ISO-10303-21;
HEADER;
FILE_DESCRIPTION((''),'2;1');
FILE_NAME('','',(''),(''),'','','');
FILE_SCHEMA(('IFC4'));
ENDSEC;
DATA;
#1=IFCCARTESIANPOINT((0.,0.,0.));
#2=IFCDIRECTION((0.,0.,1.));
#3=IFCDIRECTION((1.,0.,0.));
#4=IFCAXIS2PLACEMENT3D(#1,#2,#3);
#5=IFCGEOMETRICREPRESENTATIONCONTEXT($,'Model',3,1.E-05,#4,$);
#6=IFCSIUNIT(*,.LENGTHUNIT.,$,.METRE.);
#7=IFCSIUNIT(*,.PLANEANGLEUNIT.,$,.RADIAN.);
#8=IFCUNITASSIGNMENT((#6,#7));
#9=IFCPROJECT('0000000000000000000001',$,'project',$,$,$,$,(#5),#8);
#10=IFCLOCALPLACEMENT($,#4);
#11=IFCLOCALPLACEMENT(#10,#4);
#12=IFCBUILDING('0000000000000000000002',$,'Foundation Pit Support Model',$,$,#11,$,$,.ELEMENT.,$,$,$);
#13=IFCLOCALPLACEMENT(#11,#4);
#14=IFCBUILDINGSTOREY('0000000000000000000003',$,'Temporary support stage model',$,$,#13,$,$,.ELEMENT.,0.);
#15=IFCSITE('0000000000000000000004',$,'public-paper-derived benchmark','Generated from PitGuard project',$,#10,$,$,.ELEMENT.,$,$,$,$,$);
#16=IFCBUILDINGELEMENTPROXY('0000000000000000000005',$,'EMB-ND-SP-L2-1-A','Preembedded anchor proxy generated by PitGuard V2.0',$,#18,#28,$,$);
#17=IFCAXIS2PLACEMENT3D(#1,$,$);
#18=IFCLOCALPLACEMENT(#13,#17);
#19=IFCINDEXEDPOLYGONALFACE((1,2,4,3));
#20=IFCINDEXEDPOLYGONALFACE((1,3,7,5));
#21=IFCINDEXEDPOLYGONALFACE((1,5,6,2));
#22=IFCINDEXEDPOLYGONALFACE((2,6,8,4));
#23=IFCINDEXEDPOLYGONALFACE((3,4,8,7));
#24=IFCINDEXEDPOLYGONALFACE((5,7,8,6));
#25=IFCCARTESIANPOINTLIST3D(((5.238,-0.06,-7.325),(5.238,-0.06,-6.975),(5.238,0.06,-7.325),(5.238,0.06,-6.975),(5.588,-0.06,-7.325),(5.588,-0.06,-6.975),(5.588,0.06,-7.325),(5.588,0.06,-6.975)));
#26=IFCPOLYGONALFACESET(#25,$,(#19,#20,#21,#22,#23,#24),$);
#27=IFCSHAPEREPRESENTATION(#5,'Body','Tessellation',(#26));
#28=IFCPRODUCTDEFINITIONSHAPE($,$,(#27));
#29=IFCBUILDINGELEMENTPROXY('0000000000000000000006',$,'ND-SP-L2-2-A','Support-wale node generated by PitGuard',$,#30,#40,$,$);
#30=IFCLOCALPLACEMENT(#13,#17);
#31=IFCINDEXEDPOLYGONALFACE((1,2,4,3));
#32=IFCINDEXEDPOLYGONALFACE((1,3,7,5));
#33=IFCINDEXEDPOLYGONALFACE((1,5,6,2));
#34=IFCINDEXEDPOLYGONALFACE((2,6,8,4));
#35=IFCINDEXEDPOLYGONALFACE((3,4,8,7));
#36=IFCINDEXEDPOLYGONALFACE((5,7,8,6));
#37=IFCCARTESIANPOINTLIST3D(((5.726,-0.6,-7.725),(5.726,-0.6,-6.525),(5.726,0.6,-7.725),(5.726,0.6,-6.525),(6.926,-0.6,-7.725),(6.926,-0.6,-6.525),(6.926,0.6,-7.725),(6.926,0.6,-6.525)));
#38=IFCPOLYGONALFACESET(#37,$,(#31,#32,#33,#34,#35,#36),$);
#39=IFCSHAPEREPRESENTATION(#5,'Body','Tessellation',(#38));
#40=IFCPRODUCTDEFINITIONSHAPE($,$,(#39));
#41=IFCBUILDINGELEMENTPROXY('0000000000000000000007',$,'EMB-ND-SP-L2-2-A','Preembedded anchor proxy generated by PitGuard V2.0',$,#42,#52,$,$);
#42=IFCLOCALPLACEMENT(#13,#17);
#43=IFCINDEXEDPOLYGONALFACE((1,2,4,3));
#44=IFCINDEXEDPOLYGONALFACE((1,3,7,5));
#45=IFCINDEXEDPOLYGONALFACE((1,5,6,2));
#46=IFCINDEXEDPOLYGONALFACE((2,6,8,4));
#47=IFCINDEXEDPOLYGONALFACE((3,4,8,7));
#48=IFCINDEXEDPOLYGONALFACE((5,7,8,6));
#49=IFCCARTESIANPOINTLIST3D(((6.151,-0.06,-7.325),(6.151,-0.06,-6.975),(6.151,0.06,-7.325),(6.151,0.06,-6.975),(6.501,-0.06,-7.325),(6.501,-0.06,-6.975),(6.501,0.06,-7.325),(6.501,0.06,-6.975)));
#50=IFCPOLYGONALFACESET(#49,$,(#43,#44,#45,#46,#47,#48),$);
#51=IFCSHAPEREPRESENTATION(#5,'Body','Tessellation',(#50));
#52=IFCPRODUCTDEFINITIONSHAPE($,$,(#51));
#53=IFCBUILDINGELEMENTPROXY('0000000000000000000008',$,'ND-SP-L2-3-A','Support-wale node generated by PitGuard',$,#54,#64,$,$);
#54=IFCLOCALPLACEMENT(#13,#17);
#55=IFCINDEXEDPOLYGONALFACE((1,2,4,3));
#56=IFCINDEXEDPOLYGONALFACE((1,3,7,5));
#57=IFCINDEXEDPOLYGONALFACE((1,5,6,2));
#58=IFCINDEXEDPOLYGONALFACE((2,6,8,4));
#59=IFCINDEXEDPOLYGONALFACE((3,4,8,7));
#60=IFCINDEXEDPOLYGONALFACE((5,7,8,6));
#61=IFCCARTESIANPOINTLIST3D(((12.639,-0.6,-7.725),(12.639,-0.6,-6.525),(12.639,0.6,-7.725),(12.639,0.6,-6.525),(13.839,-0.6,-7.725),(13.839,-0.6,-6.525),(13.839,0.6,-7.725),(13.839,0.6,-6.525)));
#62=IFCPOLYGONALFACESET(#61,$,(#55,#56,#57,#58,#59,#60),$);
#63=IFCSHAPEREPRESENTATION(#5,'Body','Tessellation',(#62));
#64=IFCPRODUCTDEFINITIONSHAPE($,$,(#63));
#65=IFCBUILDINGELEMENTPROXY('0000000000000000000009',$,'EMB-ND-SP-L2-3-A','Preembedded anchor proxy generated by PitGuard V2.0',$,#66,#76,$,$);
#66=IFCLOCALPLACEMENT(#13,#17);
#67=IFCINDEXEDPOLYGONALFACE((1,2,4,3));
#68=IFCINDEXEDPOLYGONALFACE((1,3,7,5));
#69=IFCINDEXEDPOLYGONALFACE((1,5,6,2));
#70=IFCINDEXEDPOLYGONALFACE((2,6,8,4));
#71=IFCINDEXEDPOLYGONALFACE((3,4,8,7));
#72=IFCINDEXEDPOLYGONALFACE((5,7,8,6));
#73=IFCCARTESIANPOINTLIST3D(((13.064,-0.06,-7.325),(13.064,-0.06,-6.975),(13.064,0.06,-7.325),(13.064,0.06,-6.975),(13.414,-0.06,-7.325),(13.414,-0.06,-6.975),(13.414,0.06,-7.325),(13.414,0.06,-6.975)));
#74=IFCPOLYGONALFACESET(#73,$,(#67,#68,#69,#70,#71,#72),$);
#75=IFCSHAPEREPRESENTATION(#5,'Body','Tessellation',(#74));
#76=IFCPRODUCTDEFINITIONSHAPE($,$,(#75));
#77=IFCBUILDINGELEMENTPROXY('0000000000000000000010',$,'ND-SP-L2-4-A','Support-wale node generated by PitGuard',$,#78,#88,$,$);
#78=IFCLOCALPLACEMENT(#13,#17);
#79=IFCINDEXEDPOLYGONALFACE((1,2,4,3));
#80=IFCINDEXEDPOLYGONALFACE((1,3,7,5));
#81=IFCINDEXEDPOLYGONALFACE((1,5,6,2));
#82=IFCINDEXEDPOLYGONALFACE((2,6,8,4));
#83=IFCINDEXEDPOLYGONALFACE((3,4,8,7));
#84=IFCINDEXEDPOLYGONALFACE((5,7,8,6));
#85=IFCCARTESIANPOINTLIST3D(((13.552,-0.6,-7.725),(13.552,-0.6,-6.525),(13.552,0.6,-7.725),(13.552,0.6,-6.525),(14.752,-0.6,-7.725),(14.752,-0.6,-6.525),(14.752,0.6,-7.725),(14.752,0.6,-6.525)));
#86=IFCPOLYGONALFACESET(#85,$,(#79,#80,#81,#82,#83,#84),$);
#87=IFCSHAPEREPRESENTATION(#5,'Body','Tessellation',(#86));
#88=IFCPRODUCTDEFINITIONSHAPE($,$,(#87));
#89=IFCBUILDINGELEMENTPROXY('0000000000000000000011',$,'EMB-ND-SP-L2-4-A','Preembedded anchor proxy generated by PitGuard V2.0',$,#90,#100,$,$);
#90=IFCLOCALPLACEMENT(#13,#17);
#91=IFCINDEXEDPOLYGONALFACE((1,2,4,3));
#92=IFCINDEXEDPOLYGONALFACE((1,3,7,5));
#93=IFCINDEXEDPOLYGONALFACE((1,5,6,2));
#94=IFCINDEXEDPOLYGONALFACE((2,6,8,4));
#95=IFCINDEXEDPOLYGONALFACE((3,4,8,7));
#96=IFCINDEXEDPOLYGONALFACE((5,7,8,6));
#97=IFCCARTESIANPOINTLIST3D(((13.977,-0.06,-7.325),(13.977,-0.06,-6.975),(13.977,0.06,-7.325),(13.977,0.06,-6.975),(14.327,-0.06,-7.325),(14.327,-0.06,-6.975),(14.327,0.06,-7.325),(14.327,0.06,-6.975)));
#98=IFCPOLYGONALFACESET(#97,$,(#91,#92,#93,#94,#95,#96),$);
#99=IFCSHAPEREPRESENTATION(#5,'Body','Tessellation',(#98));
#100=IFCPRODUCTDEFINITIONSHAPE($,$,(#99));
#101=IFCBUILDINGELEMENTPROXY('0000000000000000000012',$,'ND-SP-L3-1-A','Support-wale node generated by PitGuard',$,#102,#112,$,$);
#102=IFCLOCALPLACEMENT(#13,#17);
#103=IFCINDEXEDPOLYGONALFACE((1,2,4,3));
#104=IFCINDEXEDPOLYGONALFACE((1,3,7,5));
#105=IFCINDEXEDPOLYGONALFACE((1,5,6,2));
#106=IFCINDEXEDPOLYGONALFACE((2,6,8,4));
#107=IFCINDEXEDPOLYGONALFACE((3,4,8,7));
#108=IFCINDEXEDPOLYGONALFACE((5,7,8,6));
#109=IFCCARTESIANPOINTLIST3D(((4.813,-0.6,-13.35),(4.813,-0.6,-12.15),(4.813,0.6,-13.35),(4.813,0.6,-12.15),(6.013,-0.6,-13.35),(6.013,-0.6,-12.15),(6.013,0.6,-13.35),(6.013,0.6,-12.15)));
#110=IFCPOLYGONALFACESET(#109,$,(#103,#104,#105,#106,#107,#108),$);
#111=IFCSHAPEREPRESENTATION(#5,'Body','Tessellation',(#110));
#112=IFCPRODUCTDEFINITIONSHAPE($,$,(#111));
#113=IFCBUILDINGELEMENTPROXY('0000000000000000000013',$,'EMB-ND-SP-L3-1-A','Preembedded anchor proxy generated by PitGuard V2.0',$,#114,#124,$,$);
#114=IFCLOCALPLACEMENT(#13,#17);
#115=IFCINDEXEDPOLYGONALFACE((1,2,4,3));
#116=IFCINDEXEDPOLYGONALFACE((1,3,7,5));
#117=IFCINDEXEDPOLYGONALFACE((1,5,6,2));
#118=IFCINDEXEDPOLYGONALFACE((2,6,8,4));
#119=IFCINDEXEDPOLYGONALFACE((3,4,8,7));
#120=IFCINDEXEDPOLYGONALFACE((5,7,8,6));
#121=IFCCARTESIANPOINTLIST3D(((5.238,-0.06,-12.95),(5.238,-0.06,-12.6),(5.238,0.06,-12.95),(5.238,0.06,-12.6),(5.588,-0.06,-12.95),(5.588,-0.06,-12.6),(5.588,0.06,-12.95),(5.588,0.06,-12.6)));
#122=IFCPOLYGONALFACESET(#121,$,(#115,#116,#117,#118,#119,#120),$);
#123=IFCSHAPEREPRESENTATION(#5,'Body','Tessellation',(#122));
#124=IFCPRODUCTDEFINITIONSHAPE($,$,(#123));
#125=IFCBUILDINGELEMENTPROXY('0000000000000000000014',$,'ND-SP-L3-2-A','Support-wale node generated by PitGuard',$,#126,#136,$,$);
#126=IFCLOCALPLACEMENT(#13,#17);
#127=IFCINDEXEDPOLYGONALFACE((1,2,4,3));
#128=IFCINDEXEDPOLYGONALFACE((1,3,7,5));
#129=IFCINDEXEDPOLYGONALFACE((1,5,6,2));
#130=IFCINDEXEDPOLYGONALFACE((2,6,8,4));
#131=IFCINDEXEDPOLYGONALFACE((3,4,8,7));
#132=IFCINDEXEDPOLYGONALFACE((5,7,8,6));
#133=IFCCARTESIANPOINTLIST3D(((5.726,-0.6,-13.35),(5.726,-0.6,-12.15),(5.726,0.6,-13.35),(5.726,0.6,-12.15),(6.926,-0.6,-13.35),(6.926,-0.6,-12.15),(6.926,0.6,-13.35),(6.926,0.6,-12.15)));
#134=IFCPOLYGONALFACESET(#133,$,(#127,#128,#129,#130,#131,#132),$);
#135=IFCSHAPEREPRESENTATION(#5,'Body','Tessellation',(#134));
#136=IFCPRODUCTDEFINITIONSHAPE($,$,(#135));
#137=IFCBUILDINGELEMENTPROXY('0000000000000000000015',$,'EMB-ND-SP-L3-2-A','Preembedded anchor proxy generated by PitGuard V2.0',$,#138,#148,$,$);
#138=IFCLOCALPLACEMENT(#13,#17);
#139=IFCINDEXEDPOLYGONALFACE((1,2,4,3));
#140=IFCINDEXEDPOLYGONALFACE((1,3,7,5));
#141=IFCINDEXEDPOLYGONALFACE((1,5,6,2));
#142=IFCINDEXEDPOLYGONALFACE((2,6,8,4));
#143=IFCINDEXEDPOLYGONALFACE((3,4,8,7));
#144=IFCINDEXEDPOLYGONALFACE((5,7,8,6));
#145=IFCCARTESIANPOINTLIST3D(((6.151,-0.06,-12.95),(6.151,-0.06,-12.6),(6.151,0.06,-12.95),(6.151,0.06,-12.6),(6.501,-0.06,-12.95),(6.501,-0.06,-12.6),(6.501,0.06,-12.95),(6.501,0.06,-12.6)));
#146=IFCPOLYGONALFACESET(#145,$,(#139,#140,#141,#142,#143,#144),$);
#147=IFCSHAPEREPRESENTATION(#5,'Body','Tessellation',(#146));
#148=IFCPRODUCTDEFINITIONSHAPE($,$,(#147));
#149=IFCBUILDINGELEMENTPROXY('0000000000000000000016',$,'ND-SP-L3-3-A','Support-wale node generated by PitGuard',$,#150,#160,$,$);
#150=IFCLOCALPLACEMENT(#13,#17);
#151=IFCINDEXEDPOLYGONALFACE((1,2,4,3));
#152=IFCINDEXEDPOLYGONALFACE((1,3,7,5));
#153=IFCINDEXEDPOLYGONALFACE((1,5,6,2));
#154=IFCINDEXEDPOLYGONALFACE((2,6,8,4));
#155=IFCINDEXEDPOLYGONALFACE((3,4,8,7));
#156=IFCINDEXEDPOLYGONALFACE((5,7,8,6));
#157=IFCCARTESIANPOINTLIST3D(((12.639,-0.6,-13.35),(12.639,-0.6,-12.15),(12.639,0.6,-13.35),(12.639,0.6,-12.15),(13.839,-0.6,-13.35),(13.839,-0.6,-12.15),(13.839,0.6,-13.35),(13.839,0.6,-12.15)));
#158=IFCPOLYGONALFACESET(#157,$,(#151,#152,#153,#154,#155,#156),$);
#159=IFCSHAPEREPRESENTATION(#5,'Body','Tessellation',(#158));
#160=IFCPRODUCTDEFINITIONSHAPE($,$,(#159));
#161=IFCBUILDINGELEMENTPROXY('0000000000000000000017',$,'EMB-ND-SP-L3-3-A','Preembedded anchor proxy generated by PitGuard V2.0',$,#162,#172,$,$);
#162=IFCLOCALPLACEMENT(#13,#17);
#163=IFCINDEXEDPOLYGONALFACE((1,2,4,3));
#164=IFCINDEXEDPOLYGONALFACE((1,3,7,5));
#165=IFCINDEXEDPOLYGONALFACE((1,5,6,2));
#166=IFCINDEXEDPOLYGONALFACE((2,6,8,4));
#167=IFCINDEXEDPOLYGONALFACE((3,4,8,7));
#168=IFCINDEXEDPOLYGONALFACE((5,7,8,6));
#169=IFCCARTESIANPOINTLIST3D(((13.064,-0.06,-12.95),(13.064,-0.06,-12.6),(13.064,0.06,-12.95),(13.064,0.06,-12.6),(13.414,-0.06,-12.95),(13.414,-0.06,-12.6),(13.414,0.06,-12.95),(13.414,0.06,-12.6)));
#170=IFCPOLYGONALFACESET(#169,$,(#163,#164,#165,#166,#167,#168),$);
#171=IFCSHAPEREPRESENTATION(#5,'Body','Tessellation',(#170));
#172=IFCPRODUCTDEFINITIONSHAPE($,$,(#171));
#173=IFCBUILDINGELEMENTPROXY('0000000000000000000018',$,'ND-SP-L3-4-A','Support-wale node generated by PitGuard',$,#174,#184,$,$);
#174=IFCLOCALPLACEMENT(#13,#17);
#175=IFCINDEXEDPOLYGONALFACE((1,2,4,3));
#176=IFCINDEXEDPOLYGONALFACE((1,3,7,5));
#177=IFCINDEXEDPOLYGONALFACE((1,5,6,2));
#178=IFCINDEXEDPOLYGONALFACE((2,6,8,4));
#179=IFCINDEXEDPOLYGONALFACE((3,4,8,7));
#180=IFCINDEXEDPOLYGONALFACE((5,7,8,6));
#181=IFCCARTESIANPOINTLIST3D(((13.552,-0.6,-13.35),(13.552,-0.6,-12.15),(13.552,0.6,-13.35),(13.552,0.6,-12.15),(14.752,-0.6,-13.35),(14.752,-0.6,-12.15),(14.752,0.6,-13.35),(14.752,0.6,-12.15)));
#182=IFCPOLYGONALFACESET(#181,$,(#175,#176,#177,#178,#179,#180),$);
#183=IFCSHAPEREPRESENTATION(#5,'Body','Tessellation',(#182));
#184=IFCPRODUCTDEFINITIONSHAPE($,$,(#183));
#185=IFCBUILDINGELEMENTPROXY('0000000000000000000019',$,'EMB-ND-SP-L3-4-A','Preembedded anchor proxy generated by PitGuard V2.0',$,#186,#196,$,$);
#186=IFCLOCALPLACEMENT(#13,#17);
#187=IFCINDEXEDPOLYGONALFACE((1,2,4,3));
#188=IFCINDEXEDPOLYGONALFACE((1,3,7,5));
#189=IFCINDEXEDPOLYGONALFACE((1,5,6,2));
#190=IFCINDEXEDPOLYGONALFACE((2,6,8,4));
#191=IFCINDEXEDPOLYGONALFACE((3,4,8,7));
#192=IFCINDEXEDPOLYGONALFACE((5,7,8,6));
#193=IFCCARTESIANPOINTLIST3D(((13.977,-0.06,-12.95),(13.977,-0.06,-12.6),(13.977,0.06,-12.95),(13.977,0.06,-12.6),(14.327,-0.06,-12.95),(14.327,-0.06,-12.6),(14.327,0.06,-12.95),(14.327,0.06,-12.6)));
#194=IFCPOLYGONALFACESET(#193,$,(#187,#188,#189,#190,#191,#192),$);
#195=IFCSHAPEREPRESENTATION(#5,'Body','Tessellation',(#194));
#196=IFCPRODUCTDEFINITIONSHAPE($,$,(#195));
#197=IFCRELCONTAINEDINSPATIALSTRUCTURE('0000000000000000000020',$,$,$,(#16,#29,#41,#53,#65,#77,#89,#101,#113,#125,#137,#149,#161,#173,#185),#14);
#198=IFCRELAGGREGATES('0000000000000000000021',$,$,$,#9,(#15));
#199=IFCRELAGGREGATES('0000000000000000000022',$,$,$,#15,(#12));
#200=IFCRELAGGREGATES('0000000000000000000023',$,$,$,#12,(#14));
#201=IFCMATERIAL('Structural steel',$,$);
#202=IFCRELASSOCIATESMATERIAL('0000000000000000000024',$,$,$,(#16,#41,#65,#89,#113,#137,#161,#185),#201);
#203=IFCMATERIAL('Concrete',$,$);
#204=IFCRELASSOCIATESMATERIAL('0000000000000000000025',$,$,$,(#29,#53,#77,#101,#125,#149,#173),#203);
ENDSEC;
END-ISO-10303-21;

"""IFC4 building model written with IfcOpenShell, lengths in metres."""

from ifc_helpers import new_model, si_unit, frame, origin_with_axes, origin_2d, place, context, project, spatial, rectangle, extrude, material, element, save


model = new_model("IFC4")

# Units and contexts
model_context = context("Model", 3, precision=1e-05, world=origin_with_axes())
ifc_project = project(units=[si_unit("LENGTHUNIT", "METRE"), si_unit("PLANEANGLEUNIT", "RADIAN")], contexts=[model_context])

# Site, building, storey
site_placement = place(None, origin_with_axes())
site = spatial("IfcSite", under=ifc_project, at=site_placement, Name="public-paper-derived benchmark", Description="Generated from PitGuard project", CompositionType="ELEMENT")
building_placement = place(site_placement, origin_with_axes())
building = spatial("IfcBuilding", under=site, at=building_placement, Name="Foundation Pit Support Model", CompositionType="ELEMENT")
storey_placement = place(building_placement, origin_with_axes())
storey = spatial("IfcBuildingStorey", under=building, at=storey_placement, Name="Temporary support stage model", CompositionType="ELEMENT", Elevation=0.0)

# Shared definitions
ifc_material_1 = material(Name="Structural steel")

# Building element proxies
ifc_material_2 = material(Name="Concrete")
proxy_1_placement = place(storey_placement, frame((5.413, 0.0, -7.325), z_axis=(0.0, 0.0, 1.0), x_axis=(1.0, 0.0, 0.0)))
element("IfcBuildingElementProxy", 1, at=proxy_1_placement, inside=storey, material=ifc_material_1, Name="EMB-ND-SP-L2-1-A", Description="Preembedded anchor proxy generated by PitGuard V2.0", context=model_context, shape_type="SweptSolid", body=[
    extrude(rectangle(XDim=0.35, YDim=0.12, at=origin_2d()), origin_with_axes(), (0.0, 0.0, 1.0), 0.35),
])
proxy_2_placement = place(storey_placement, frame((6.326, 0.0, -7.725), z_axis=(0.0, 0.0, 1.0), x_axis=(1.0, 0.0, 0.0)))
element("IfcBuildingElementProxy", 2, at=proxy_2_placement, inside=storey, material=ifc_material_2, Name="ND-SP-L2-2-A", Description="Support-wale node generated by PitGuard", context=model_context, shape_type="SweptSolid", body=[
    extrude(rectangle(XDim=1.2, YDim=1.2, at=origin_2d()), origin_with_axes(), (0.0, 0.0, 1.0), 1.2),
])
proxy_3_placement = place(storey_placement, frame((6.326, 0.0, -7.325), z_axis=(0.0, 0.0, 1.0), x_axis=(1.0, 0.0, 0.0)))
element("IfcBuildingElementProxy", 3, at=proxy_3_placement, inside=storey, material=ifc_material_1, Name="EMB-ND-SP-L2-2-A", Description="Preembedded anchor proxy generated by PitGuard V2.0", context=model_context, shape_type="SweptSolid", body=[
    extrude(rectangle(XDim=0.35, YDim=0.12, at=origin_2d()), origin_with_axes(), (0.0, 0.0, 1.0), 0.35),
])
proxy_4_placement = place(storey_placement, frame((13.239, 0.0, -7.725), z_axis=(0.0, 0.0, 1.0), x_axis=(1.0, 0.0, 0.0)))
element("IfcBuildingElementProxy", 4, at=proxy_4_placement, inside=storey, material=ifc_material_2, Name="ND-SP-L2-3-A", Description="Support-wale node generated by PitGuard", context=model_context, shape_type="SweptSolid", body=[
    extrude(rectangle(XDim=1.2, YDim=1.2, at=origin_2d()), origin_with_axes(), (0.0, 0.0, 1.0), 1.2),
])
proxy_5_placement = place(storey_placement, frame((13.239, 0.0, -7.325), z_axis=(0.0, 0.0, 1.0), x_axis=(1.0, 0.0, 0.0)))
element("IfcBuildingElementProxy", 5, at=proxy_5_placement, inside=storey, material=ifc_material_1, Name="EMB-ND-SP-L2-3-A", Description="Preembedded anchor proxy generated by PitGuard V2.0", context=model_context, shape_type="SweptSolid", body=[
    extrude(rectangle(XDim=0.35, YDim=0.12, at=origin_2d()), origin_with_axes(), (0.0, 0.0, 1.0), 0.35),
])
proxy_6_placement = place(storey_placement, frame((14.152, 0.0, -7.725), z_axis=(0.0, 0.0, 1.0), x_axis=(1.0, 0.0, 0.0)))
element("IfcBuildingElementProxy", 6, at=proxy_6_placement, inside=storey, material=ifc_material_2, Name="ND-SP-L2-4-A", Description="Support-wale node generated by PitGuard", context=model_context, shape_type="SweptSolid", body=[
    extrude(rectangle(XDim=1.2, YDim=1.2, at=origin_2d()), origin_with_axes(), (0.0, 0.0, 1.0), 1.2),
])
proxy_7_placement = place(storey_placement, frame((14.152, 0.0, -7.325), z_axis=(0.0, 0.0, 1.0), x_axis=(1.0, 0.0, 0.0)))
element("IfcBuildingElementProxy", 7, at=proxy_7_placement, inside=storey, material=ifc_material_1, Name="EMB-ND-SP-L2-4-A", Description="Preembedded anchor proxy generated by PitGuard V2.0", context=model_context, shape_type="SweptSolid", body=[
    extrude(rectangle(XDim=0.35, YDim=0.12, at=origin_2d()), origin_with_axes(), (0.0, 0.0, 1.0), 0.35),
])
proxy_8_placement = place(storey_placement, frame((5.413, 0.0, -13.35), z_axis=(0.0, 0.0, 1.0), x_axis=(1.0, 0.0, 0.0)))
element("IfcBuildingElementProxy", 8, at=proxy_8_placement, inside=storey, material=ifc_material_2, Name="ND-SP-L3-1-A", Description="Support-wale node generated by PitGuard", context=model_context, shape_type="SweptSolid", body=[
    extrude(rectangle(XDim=1.2, YDim=1.2, at=origin_2d()), origin_with_axes(), (0.0, 0.0, 1.0), 1.2),
])
proxy_9_placement = place(storey_placement, frame((5.413, 0.0, -12.95), z_axis=(0.0, 0.0, 1.0), x_axis=(1.0, 0.0, 0.0)))
element("IfcBuildingElementProxy", 9, at=proxy_9_placement, inside=storey, material=ifc_material_1, Name="EMB-ND-SP-L3-1-A", Description="Preembedded anchor proxy generated by PitGuard V2.0", context=model_context, shape_type="SweptSolid", body=[
    extrude(rectangle(XDim=0.35, YDim=0.12, at=origin_2d()), origin_with_axes(), (0.0, 0.0, 1.0), 0.35),
])
proxy_10_placement = place(storey_placement, frame((6.326, 0.0, -13.35), z_axis=(0.0, 0.0, 1.0), x_axis=(1.0, 0.0, 0.0)))
element("IfcBuildingElementProxy", 10, at=proxy_10_placement, inside=storey, material=ifc_material_2, Name="ND-SP-L3-2-A", Description="Support-wale node generated by PitGuard", context=model_context, shape_type="SweptSolid", body=[
    extrude(rectangle(XDim=1.2, YDim=1.2, at=origin_2d()), origin_with_axes(), (0.0, 0.0, 1.0), 1.2),
])
proxy_11_placement = place(storey_placement, frame((6.326, 0.0, -12.95), z_axis=(0.0, 0.0, 1.0), x_axis=(1.0, 0.0, 0.0)))
element("IfcBuildingElementProxy", 11, at=proxy_11_placement, inside=storey, material=ifc_material_1, Name="EMB-ND-SP-L3-2-A", Description="Preembedded anchor proxy generated by PitGuard V2.0", context=model_context, shape_type="SweptSolid", body=[
    extrude(rectangle(XDim=0.35, YDim=0.12, at=origin_2d()), origin_with_axes(), (0.0, 0.0, 1.0), 0.35),
])
proxy_12_placement = place(storey_placement, frame((13.239, 0.0, -13.35), z_axis=(0.0, 0.0, 1.0), x_axis=(1.0, 0.0, 0.0)))
element("IfcBuildingElementProxy", 12, at=proxy_12_placement, inside=storey, material=ifc_material_2, Name="ND-SP-L3-3-A", Description="Support-wale node generated by PitGuard", context=model_context, shape_type="SweptSolid", body=[
    extrude(rectangle(XDim=1.2, YDim=1.2, at=origin_2d()), origin_with_axes(), (0.0, 0.0, 1.0), 1.2),
])
proxy_13_placement = place(storey_placement, frame((13.239, 0.0, -12.95), z_axis=(0.0, 0.0, 1.0), x_axis=(1.0, 0.0, 0.0)))
element("IfcBuildingElementProxy", 13, at=proxy_13_placement, inside=storey, material=ifc_material_1, Name="EMB-ND-SP-L3-3-A", Description="Preembedded anchor proxy generated by PitGuard V2.0", context=model_context, shape_type="SweptSolid", body=[
    extrude(rectangle(XDim=0.35, YDim=0.12, at=origin_2d()), origin_with_axes(), (0.0, 0.0, 1.0), 0.35),
])
proxy_14_placement = place(storey_placement, frame((14.152, 0.0, -13.35), z_axis=(0.0, 0.0, 1.0), x_axis=(1.0, 0.0, 0.0)))
element("IfcBuildingElementProxy", 14, at=proxy_14_placement, inside=storey, material=ifc_material_2, Name="ND-SP-L3-4-A", Description="Support-wale node generated by PitGuard", context=model_context, shape_type="SweptSolid", body=[
    extrude(rectangle(XDim=1.2, YDim=1.2, at=origin_2d()), origin_with_axes(), (0.0, 0.0, 1.0), 1.2),
])
proxy_15_placement = place(storey_placement, frame((14.152, 0.0, -12.95), z_axis=(0.0, 0.0, 1.0), x_axis=(1.0, 0.0, 0.0)))
element("IfcBuildingElementProxy", 15, at=proxy_15_placement, inside=storey, material=ifc_material_1, Name="EMB-ND-SP-L3-4-A", Description="Preembedded anchor proxy generated by PitGuard V2.0", context=model_context, shape_type="SweptSolid", body=[
    extrude(rectangle(XDim=0.35, YDim=0.12, at=origin_2d()), origin_with_axes(), (0.0, 0.0, 1.0), 0.35),
])

save(model, "model.ifc")
